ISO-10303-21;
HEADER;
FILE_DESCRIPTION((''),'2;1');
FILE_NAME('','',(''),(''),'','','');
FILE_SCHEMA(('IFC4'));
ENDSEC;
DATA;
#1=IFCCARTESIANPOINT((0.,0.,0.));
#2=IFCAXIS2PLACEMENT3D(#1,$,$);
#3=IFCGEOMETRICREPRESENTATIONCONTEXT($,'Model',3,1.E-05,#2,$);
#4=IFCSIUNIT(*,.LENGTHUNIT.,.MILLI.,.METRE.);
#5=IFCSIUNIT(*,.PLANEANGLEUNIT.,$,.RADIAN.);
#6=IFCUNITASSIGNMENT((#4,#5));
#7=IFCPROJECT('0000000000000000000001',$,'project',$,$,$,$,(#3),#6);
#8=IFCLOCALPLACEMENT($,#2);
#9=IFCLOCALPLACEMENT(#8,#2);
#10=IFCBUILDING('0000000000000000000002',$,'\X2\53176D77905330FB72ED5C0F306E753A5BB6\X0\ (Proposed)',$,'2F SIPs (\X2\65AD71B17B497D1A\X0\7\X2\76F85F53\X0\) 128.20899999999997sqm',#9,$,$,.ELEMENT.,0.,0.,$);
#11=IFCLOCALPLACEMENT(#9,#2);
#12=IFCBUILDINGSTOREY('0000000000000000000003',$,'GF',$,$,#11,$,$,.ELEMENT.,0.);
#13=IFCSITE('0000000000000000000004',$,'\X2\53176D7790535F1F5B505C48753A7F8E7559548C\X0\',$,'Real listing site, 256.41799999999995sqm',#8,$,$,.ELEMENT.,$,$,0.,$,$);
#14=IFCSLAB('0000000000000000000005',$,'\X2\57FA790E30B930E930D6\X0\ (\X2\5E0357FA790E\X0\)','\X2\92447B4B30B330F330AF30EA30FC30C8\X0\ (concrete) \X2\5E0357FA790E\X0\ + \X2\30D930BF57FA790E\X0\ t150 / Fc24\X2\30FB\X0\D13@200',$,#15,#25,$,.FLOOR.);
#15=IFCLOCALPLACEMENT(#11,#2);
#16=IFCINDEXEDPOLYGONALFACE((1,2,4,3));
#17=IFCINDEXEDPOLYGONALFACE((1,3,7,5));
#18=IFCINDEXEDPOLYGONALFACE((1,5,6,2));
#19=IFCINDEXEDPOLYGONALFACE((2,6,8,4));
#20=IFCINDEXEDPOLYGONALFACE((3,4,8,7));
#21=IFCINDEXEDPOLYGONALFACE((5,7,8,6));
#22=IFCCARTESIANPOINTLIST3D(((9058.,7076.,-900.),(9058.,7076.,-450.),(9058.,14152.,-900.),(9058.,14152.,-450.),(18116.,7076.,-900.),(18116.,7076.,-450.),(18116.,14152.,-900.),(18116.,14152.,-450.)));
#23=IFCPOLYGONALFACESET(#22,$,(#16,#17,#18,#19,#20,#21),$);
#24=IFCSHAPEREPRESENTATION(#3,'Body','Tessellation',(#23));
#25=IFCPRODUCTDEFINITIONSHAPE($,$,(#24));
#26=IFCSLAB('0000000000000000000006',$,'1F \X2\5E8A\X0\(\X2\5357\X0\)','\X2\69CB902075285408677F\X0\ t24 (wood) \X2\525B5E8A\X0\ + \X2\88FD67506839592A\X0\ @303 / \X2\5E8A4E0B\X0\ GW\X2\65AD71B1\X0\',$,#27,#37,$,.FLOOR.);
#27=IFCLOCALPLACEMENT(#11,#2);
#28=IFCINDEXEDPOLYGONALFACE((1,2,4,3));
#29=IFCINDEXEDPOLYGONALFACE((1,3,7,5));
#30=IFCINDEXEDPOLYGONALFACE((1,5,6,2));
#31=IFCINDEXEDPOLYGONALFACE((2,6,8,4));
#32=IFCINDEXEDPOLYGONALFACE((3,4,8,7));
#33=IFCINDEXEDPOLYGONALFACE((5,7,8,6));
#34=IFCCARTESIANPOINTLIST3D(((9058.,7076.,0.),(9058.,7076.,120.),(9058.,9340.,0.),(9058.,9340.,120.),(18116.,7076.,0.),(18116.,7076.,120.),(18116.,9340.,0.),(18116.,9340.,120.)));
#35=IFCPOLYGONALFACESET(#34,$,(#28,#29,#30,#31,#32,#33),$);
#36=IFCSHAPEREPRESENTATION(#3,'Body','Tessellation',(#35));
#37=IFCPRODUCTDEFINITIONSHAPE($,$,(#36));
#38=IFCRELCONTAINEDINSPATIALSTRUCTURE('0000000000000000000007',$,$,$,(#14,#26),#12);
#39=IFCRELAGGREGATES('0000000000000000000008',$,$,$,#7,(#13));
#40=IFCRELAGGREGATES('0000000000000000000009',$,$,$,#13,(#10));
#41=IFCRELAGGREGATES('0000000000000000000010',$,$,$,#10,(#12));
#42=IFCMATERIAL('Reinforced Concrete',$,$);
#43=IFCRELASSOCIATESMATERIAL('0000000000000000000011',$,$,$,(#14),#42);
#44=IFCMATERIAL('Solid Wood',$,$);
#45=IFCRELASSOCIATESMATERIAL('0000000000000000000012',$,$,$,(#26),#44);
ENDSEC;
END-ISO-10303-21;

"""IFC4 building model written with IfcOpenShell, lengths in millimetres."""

from ifc_helpers import new_model, si_unit, frame, frame_2d, origin, place, context, project, spatial, rectangle, extrude, material, element, save


model = new_model("IFC4")

# Units and contexts
model_context = context("Model", 3, precision=1e-05, world=origin())
ifc_project = project(units=[si_unit("LENGTHUNIT", "METRE", prefix="MILLI"), si_unit("PLANEANGLEUNIT", "RADIAN")], contexts=[model_context])

# Site, building, storey
site_placement = place(None, origin())
site = spatial("IfcSite", under=ifc_project, at=site_placement, Name="北海道弟子屈町美留和", ObjectType="Real listing site, 256.41799999999995sqm", CompositionType="ELEMENT", RefElevation=0.0)
building_placement = place(site_placement, origin())
building = spatial("IfcBuilding", under=site, at=building_placement, Name="北海道・狭小の町家 (Proposed)", ObjectType="2F SIPs (断熱等級7相当) 128.20899999999997sqm", CompositionType="ELEMENT", ElevationOfRefHeight=0.0, ElevationOfTerrain=0.0)
storey_placement = place(building_placement, origin())
storey = spatial("IfcBuildingStorey", under=building, at=storey_placement, Name="GF", CompositionType="ELEMENT", Elevation=0.0)

# Slabs
ifc_material_1 = material(Name="Reinforced Concrete")
slab_1_placement = place(storey_placement, frame((4529.0, 3538.0, -450.0)))
element("IfcSlab", 1, at=slab_1_placement, inside=storey, material=ifc_material_1, Name="基礎スラブ (布基礎)", Description="鉄筋コンクリート (concrete) 布基礎 + ベタ基礎 t150 / Fc24・D13@200", PredefinedType="FLOOR", context=model_context, shape_type="SweptSolid", body=[
    extrude(rectangle(XDim=9058.0, YDim=7076.0, at=frame_2d((4529.0, 3538.0))), frame((4529.0, 3538.0, -450.0)), (0.0, 0.0, 1.0), 450.0),
])
ifc_material_2 = material(Name="Solid Wood")
slab_2_placement = place(storey_placement, frame((4529.0, 3538.0, 0.0)))
element("IfcSlab", 2, at=slab_2_placement, inside=storey, material=ifc_material_2, Name="1F 床(南)", Description="構造用合板 t24 (wood) 剛床 + 製材根太 @303 / 床下 GW断熱", PredefinedType="FLOOR", context=model_context, shape_type="SweptSolid", body=[
    extrude(rectangle(XDim=9058.0, YDim=2264.0, at=frame_2d((4529.0, 1132.0))), frame((4529.0, 3538.0, 0.0)), (0.0, 0.0, 1.0), 120.0),
])

save(model, "model.ifc")
